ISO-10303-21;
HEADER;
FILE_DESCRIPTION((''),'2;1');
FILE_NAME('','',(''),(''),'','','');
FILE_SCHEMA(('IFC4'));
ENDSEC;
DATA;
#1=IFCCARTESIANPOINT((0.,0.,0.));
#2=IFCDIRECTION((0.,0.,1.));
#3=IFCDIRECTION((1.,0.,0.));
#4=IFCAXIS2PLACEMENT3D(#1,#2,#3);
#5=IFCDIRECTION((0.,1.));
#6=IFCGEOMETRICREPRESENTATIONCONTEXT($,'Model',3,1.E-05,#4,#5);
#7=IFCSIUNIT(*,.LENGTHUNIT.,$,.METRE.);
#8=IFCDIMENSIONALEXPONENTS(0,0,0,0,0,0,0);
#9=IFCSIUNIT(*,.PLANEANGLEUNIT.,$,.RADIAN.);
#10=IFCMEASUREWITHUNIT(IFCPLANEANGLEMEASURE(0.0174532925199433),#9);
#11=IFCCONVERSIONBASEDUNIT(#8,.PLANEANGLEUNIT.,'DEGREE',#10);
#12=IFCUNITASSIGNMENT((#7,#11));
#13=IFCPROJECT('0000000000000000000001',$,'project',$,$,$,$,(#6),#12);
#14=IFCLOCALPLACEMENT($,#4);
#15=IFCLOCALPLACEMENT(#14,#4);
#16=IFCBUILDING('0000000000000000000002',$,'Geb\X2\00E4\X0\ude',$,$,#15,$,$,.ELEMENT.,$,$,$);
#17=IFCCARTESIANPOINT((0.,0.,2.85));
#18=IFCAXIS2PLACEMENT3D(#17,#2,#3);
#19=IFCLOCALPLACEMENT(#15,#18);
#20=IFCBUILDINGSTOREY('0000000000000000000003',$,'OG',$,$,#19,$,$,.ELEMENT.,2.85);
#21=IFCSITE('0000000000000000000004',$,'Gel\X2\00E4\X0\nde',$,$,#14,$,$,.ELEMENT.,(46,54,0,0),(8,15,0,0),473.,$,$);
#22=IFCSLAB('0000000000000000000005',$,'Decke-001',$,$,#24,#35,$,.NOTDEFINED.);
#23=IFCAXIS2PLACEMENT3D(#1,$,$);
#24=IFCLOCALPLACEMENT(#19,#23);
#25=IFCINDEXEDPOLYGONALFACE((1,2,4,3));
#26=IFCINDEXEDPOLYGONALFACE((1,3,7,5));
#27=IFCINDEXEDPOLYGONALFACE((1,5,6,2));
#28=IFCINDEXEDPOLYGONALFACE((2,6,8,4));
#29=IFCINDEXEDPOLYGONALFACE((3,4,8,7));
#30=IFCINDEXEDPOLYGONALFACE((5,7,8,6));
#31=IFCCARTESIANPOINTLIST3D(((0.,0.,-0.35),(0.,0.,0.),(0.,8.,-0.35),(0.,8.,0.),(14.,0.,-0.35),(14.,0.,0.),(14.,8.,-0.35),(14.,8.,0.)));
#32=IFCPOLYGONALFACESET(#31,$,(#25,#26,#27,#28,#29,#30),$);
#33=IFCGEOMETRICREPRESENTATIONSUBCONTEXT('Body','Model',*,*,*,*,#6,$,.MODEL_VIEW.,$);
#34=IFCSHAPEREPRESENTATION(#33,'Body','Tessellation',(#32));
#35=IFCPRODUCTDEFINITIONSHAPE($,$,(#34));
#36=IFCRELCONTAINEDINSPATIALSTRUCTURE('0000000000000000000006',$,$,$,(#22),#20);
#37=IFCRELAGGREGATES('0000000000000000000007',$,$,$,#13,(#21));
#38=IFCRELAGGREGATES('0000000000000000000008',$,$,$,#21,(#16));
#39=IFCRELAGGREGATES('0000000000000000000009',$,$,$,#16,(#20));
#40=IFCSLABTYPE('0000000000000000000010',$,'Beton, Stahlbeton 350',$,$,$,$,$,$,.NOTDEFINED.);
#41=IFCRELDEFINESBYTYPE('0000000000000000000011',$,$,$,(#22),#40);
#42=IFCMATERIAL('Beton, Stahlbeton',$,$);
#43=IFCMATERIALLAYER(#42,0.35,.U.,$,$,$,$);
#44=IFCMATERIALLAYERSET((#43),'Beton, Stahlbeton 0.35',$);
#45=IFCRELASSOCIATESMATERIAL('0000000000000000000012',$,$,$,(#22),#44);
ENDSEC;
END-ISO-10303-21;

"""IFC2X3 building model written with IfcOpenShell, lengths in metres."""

from ifc_helpers import new_model, entity, si_unit, converted_unit, direction, frame, origin_with_axes, place, context, subcontext, project, spatial, polyline, outline, extrude, material, layer, layer_set, layer_usage, type_object, element, save


model = new_model("IFC2X3")

# Units and contexts
model_context = context("Model", 3, precision=1e-05, world=origin_with_axes(), true_north=direction((0.0, 1.0)))
body_context = subcontext(model_context, "Body", "Model", "MODEL_VIEW")
ifc_project = project(units=[si_unit("LENGTHUNIT", "METRE"), converted_unit("PLANEANGLEUNIT", "DEGREE", entity("IfcPlaneAngleMeasure", 0.0174532925199433), si_unit("PLANEANGLEUNIT", "RADIAN"), dimensions=[0, 0, 0, 0, 0, 0, 0])], contexts=[model_context])

# Site, building, storey
site_placement = place(None, origin_with_axes())
site = spatial("IfcSite", under=ifc_project, at=site_placement, Name="Gelände", CompositionType="ELEMENT", RefLatitude=(46, 54, 0, 0), RefLongitude=(8, 15, 0, 0), RefElevation=473.0)
building_placement = place(site_placement, origin_with_axes())
building = spatial("IfcBuilding", under=site, at=building_placement, Name="Gebäude", CompositionType="ELEMENT")
storey_placement = place(building_placement, frame((0.0, 0.0, 2.85), z_axis=(0.0, 0.0, 1.0), x_axis=(1.0, 0.0, 0.0)))
storey = spatial("IfcBuildingStorey", under=building, at=storey_placement, Name="OG", CompositionType="ELEMENT", Elevation=2.85)

# Slab
ifc_material = material(Name="Beton, Stahlbeton")
ifc_layer = layer(ifc_material, 0.35, ventilated="UNKNOWN")
ifc_layer_set = layer_set([ifc_layer], Name="Beton, Stahlbeton 0.35")
ifc_layer_usage = layer_usage(ifc_layer_set, "AXIS3", "NEGATIVE", 0.35)
slab_type = type_object("IfcSlabType", Name="Beton, Stahlbeton 350", PredefinedType="NOTDEFINED")
slab_placement = place(storey_placement, origin_with_axes())
element("IfcSlab", 1, at=slab_placement, inside=storey, type_object=slab_type, material=ifc_layer_usage, Name="Decke-001", PredefinedType="NOTDEFINED", context=body_context, shape_type="SweptSolid", body=[
    extrude(outline(polyline([(0.0, 0.0), (14.0, 0.0), (14.0, 8.0), (0.0, 8.0), (0.0, 0.0)])), frame((0.0, 0.0, -0.35), z_axis=(0.0, 0.0, 1.0), x_axis=(1.0, 0.0, 0.0)), (0.0, 0.0, 1.0), 0.35),
])

save(model, "model.ifc")
